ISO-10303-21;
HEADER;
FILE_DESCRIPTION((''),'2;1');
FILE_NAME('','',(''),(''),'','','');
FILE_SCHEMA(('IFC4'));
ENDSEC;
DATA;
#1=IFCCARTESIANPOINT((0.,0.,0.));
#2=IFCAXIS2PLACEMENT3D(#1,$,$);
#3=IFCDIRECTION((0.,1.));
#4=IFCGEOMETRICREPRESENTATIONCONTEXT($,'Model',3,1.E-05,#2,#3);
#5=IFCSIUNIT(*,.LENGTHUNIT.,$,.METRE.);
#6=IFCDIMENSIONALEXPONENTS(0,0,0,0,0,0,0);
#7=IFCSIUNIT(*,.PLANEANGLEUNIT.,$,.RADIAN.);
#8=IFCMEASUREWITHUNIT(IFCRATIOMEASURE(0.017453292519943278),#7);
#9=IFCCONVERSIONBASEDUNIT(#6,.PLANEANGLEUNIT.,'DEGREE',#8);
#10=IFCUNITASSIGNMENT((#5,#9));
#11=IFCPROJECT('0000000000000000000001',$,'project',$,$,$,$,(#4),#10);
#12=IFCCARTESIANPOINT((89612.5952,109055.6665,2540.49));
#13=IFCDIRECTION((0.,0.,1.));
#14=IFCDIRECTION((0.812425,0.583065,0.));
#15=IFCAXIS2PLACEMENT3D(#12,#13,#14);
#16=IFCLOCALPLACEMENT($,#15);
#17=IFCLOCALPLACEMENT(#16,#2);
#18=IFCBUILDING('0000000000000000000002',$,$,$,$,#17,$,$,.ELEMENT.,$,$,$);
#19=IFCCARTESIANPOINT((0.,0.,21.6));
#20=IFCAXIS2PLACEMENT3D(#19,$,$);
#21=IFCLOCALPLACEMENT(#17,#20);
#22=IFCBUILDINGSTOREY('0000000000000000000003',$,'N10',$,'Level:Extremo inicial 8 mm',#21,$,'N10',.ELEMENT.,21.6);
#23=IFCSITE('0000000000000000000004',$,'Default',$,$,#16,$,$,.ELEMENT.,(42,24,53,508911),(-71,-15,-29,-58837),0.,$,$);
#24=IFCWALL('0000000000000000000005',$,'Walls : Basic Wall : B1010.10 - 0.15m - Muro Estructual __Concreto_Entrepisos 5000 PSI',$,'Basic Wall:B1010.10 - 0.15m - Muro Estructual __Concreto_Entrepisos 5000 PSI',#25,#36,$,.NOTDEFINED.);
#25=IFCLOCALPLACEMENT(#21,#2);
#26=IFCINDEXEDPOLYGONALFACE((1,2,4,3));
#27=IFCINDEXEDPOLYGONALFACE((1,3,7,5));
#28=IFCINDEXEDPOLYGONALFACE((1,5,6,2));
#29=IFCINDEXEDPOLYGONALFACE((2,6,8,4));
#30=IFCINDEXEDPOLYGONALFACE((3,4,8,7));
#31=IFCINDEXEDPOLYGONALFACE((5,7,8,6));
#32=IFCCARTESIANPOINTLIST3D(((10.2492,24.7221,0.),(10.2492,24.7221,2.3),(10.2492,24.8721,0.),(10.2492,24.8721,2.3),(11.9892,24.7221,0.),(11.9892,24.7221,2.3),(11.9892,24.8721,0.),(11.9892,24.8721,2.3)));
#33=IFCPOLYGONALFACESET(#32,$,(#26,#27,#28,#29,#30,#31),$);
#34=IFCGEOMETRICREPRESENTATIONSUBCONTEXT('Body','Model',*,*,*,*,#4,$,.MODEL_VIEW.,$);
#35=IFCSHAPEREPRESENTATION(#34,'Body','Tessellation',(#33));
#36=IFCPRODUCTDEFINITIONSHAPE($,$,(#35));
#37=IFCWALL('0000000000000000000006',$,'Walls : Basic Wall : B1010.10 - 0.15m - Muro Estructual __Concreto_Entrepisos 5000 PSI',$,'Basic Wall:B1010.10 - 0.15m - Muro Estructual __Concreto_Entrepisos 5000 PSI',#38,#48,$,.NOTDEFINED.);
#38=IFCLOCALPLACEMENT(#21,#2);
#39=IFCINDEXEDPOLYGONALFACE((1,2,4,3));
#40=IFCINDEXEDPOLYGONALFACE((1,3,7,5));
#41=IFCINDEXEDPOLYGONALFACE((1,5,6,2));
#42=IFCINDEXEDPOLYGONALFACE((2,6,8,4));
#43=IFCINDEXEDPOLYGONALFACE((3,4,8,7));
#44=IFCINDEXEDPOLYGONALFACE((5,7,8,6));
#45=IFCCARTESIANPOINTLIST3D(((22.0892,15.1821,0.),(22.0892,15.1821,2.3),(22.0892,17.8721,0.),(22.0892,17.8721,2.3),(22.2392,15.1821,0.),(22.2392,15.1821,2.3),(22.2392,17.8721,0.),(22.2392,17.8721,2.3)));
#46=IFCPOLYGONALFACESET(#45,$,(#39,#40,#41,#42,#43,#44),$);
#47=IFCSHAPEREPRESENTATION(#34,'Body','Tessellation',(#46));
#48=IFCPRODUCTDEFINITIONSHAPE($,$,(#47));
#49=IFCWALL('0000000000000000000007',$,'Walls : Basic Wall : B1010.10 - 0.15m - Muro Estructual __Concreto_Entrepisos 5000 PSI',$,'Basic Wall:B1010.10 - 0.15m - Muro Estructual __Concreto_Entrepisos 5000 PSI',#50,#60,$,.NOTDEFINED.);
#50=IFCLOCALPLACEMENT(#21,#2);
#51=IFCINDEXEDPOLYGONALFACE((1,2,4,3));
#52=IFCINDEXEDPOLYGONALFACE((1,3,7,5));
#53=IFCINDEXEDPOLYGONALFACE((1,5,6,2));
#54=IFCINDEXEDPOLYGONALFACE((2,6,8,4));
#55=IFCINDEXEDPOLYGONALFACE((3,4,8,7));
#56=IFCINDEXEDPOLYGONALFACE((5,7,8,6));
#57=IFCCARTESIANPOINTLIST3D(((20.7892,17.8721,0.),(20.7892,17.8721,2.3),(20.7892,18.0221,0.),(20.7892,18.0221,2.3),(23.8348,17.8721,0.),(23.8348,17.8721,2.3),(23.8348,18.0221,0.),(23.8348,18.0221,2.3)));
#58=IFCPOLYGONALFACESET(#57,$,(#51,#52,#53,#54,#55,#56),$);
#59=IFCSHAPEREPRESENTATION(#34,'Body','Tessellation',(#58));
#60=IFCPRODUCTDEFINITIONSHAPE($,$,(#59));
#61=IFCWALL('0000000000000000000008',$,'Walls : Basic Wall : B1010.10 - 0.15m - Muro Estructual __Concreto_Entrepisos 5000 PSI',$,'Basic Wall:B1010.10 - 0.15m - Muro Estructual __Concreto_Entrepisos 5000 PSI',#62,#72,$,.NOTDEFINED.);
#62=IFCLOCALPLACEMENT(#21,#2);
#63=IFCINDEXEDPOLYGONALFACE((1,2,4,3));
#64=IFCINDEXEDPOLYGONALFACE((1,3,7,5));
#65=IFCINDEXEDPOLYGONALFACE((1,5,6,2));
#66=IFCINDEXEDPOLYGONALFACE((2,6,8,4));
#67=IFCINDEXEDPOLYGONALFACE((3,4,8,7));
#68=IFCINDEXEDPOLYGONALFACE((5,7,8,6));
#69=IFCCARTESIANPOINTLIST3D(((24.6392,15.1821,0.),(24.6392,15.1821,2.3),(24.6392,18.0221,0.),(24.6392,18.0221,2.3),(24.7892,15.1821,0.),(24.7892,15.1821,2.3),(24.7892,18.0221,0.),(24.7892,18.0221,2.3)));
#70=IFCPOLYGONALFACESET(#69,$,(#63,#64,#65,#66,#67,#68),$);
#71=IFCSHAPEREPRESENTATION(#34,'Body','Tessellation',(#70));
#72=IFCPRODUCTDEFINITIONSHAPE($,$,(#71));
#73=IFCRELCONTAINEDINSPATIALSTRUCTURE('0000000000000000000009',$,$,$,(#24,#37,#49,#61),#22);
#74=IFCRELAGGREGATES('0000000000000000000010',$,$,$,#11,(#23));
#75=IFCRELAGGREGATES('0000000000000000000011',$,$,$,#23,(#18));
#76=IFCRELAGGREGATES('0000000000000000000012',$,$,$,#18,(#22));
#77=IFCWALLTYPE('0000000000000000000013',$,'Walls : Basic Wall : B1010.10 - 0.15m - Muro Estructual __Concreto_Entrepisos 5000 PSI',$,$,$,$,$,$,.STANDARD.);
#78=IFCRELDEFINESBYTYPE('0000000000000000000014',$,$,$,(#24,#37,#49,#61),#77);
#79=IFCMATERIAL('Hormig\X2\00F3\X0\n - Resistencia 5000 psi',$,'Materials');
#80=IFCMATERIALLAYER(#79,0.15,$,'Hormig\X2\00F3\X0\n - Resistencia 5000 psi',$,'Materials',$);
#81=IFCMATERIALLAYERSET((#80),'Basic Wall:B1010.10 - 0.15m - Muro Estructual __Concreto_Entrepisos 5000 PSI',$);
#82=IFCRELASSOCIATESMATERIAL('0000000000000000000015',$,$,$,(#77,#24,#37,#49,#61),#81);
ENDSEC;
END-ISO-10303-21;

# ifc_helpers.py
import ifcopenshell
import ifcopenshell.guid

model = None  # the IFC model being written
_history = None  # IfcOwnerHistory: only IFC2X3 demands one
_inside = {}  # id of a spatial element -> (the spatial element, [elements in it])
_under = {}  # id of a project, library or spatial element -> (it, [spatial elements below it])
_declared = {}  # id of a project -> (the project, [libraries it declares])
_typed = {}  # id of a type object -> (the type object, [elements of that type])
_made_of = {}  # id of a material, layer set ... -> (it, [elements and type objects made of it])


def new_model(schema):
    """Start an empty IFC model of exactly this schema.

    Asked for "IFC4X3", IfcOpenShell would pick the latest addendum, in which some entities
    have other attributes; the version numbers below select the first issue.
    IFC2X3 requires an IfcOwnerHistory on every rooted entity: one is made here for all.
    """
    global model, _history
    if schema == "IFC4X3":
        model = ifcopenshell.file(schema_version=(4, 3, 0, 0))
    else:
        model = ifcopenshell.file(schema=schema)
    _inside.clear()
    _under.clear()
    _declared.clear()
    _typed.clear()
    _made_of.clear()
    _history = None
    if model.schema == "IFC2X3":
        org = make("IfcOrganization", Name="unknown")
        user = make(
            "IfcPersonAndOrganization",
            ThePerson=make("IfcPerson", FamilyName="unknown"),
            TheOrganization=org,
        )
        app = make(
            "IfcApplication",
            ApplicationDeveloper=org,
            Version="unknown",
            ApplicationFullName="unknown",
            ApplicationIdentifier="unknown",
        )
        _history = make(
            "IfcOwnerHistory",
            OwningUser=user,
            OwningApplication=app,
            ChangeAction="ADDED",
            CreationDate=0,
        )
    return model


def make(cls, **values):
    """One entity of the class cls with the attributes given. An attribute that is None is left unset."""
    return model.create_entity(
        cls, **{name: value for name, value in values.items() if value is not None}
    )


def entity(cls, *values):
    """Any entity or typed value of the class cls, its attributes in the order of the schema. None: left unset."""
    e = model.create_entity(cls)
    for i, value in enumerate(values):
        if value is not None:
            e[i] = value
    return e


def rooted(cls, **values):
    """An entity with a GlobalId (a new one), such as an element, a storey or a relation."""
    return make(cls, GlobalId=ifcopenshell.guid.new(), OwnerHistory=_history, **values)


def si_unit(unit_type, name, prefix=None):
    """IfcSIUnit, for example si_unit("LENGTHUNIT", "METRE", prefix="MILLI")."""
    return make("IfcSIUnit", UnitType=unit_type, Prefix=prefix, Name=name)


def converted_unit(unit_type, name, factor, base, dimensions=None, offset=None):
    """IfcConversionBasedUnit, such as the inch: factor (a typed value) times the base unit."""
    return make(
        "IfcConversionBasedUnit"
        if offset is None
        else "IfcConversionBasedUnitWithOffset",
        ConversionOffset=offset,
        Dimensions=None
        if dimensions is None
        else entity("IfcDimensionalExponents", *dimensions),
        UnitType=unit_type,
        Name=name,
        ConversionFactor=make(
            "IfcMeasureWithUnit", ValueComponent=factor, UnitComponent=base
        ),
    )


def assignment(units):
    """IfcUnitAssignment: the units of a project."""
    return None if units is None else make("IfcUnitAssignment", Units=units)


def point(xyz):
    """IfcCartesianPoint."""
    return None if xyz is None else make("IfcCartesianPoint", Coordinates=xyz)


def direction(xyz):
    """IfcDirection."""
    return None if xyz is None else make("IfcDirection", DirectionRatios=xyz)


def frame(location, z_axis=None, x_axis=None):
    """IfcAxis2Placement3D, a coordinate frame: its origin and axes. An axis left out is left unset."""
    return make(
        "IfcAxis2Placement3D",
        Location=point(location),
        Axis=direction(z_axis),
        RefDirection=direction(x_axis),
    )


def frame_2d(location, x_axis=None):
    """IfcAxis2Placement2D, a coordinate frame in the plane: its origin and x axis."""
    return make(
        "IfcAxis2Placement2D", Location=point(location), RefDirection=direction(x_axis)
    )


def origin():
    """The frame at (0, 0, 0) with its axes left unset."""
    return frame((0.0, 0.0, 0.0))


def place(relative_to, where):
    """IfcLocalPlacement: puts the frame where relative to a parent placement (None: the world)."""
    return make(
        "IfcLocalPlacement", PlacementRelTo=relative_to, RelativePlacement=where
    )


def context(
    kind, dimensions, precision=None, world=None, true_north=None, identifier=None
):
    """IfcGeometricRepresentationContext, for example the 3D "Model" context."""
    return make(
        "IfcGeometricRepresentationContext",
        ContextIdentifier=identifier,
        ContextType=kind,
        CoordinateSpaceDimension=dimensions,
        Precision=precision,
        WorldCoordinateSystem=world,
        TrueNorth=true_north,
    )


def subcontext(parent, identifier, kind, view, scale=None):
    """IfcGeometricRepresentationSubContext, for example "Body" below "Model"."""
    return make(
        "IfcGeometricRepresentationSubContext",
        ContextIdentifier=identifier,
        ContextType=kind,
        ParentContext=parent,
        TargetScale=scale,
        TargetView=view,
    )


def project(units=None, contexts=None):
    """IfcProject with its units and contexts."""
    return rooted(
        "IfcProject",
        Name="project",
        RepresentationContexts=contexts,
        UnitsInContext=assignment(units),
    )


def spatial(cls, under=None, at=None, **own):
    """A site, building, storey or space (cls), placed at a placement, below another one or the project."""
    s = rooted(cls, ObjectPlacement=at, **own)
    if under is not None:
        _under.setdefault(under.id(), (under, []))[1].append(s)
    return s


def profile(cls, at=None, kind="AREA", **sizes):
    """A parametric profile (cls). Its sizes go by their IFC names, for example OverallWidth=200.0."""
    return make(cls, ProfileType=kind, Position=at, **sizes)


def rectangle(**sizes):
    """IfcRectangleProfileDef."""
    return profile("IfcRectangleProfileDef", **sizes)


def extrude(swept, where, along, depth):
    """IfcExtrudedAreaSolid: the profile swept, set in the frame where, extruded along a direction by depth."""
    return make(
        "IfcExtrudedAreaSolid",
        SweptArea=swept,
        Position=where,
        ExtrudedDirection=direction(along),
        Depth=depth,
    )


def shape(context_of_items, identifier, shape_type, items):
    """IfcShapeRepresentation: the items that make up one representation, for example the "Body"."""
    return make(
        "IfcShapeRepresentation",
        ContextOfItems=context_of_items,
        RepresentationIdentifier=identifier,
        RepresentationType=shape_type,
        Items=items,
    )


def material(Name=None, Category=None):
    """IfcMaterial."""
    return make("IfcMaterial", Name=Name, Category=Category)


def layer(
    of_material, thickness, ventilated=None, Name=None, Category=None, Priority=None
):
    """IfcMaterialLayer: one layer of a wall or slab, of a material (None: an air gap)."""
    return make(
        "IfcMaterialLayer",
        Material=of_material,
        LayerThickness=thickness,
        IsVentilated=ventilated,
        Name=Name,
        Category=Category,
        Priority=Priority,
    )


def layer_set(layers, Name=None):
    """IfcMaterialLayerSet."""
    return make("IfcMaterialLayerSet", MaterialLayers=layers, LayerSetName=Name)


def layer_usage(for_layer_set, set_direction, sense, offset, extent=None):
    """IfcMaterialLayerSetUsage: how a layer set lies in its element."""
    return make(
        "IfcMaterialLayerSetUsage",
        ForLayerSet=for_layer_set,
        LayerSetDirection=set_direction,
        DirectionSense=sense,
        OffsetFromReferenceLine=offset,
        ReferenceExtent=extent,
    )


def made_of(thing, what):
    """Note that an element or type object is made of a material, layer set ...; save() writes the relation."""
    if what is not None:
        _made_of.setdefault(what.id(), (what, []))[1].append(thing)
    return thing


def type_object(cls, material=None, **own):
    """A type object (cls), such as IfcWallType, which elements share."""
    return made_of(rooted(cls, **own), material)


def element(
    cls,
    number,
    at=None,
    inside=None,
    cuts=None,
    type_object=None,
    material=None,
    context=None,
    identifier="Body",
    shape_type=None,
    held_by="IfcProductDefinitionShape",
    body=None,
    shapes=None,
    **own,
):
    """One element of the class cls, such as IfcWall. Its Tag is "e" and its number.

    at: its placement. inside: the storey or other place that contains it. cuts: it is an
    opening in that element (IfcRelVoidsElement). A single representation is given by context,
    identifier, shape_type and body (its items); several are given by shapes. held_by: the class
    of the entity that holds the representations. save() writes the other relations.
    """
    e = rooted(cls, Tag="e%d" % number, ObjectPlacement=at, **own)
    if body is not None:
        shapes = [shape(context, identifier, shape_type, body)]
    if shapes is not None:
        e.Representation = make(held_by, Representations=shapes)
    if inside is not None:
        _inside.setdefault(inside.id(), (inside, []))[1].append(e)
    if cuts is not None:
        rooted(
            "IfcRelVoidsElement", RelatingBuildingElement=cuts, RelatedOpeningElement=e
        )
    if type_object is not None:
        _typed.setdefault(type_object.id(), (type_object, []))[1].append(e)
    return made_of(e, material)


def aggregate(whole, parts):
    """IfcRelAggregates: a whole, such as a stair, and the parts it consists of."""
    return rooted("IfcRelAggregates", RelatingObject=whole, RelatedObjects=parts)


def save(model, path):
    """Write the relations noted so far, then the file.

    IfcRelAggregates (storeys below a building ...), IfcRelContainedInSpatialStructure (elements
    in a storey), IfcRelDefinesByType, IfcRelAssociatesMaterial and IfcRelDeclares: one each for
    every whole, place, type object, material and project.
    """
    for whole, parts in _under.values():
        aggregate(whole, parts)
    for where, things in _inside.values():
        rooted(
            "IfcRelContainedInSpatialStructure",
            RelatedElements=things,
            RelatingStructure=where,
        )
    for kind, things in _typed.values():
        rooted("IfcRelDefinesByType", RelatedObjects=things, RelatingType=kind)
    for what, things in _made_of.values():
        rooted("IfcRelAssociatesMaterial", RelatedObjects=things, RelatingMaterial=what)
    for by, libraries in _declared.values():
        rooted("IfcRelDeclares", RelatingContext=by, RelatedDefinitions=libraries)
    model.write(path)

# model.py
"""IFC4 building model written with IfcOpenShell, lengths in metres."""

from ifc_helpers import new_model, entity, si_unit, converted_unit, direction, frame, frame_2d, origin, place, context, subcontext, project, spatial, rectangle, extrude, material, layer, layer_set, layer_usage, type_object, element, save


model = new_model("IFC4")

# Units and contexts
model_context = context("Model", 3, precision=1e-05, world=origin(), true_north=direction((0.0, 1.0)))
body_context = subcontext(model_context, "Body", "Model", "MODEL_VIEW")
ifc_project = project(units=[si_unit("LENGTHUNIT", "METRE"), converted_unit("PLANEANGLEUNIT", "DEGREE", entity("IfcRatioMeasure", 0.017453292519943278), si_unit("PLANEANGLEUNIT", "RADIAN"), dimensions=[0, 0, 0, 0, 0, 0, 0])], contexts=[model_context])

# Site, building, storey
site_placement = place(None, frame((89612.5952, 109055.6665, 2540.49), z_axis=(0.0, 0.0, 1.0), x_axis=(0.812425, 0.583065, 0.0)))
site = spatial("IfcSite", under=ifc_project, at=site_placement, Name="Default", CompositionType="ELEMENT", RefLatitude=(42, 24, 53, 508911), RefLongitude=(-71, -15, -29, -58837), RefElevation=0.0)
building_placement = place(site_placement, origin())
building = spatial("IfcBuilding", under=site, at=building_placement, CompositionType="ELEMENT")
storey_placement = place(building_placement, frame((0.0, 0.0, 21.6)))
storey = spatial("IfcBuildingStorey", under=building, at=storey_placement, Name="N10", ObjectType="Level:Extremo inicial 8 mm", LongName="N10", CompositionType="ELEMENT", Elevation=21.6)

# Walls
ifc_material = material(Name="Hormigón - Resistencia 5000 psi", Category="Materials")
ifc_layer_1 = layer(ifc_material, 0.15, Name="Hormigón - Resistencia 5000 psi", Category="Materials")
ifc_layer_set_1 = layer_set([ifc_layer_1], Name="Basic Wall:B1010.10 - 0.15m - Muro Estructual __Concreto_Entrepisos 5000 PSI")
wall_type_1 = type_object("IfcWallType", Name="Walls : Basic Wall : B1010.10 - 0.15m - Muro Estructual __Concreto_Entrepisos 5000 PSI", PredefinedType="STANDARD", material=ifc_layer_set_1)
ifc_layer_usage_1 = layer_usage(ifc_layer_set_1, "AXIS2", "POSITIVE", -0.075)
wall_1_placement = place(storey_placement, frame((11.9892, 24.7971, 0.0), z_axis=(0.0, 0.0, 1.0), x_axis=(-1.0, 0.0, 0.0)))
element("IfcWall", 1, at=wall_1_placement, inside=storey, type_object=wall_type_1, material=ifc_layer_usage_1, Name="Walls : Basic Wall : B1010.10 - 0.15m - Muro Estructual __Concreto_Entrepisos 5000 PSI", ObjectType="Basic Wall:B1010.10 - 0.15m - Muro Estructual __Concreto_Entrepisos 5000 PSI", PredefinedType="NOTDEFINED", context=body_context, shape_type="SweptSolid", body=[
    extrude(rectangle(XDim=1.74, YDim=0.15, at=frame_2d((0.87, 0.0), x_axis=(-1.0, 0.0))), origin(), (0.0, 0.0, 1.0), 2.3),
])
ifc_layer_usage_2 = layer_usage(ifc_layer_set_1, "AXIS2", "POSITIVE", -0.075)
wall_2_placement = place(storey_placement, frame((22.1642, 15.1821, 0.0), z_axis=(0.0, 0.0, 1.0), x_axis=(0.0, 1.0, 0.0)))
element("IfcWall", 2, at=wall_2_placement, inside=storey, type_object=wall_type_1, material=ifc_layer_usage_2, Name="Walls : Basic Wall : B1010.10 - 0.15m - Muro Estructual __Concreto_Entrepisos 5000 PSI", ObjectType="Basic Wall:B1010.10 - 0.15m - Muro Estructual __Concreto_Entrepisos 5000 PSI", PredefinedType="NOTDEFINED", context=body_context, shape_type="SweptSolid", body=[
    extrude(rectangle(XDim=2.69, YDim=0.15, at=frame_2d((1.345, 0.0), x_axis=(-1.0, 0.0))), origin(), (0.0, 0.0, 1.0), 2.3),
])
ifc_layer_usage_3 = layer_usage(ifc_layer_set_1, "AXIS2", "POSITIVE", -0.075)
wall_3_placement = place(storey_placement, frame((20.7892, 17.9471, 0.0)))
element("IfcWall", 3, at=wall_3_placement, inside=storey, type_object=wall_type_1, material=ifc_layer_usage_3, Name="Walls : Basic Wall : B1010.10 - 0.15m - Muro Estructual __Concreto_Entrepisos 5000 PSI", ObjectType="Basic Wall:B1010.10 - 0.15m - Muro Estructual __Concreto_Entrepisos 5000 PSI", PredefinedType="NOTDEFINED", context=body_context, shape_type="SweptSolid", body=[
    extrude(rectangle(XDim=3.0455, YDim=0.15, at=frame_2d((1.5228, 0.0), x_axis=(-1.0, 0.0))), origin(), (0.0, 0.0, 1.0), 2.3),
])
ifc_layer_usage_4 = layer_usage(ifc_layer_set_1, "AXIS2", "POSITIVE", -0.075)
wall_4_placement = place(storey_placement, frame((24.7142, 15.1821, 0.0), z_axis=(0.0, 0.0, 1.0), x_axis=(0.0, 1.0, 0.0)))
element("IfcWall", 4, at=wall_4_placement, inside=storey, type_object=wall_type_1, material=ifc_layer_usage_4, Name="Walls : Basic Wall : B1010.10 - 0.15m - Muro Estructual __Concreto_Entrepisos 5000 PSI", ObjectType="Basic Wall:B1010.10 - 0.15m - Muro Estructual __Concreto_Entrepisos 5000 PSI", PredefinedType="NOTDEFINED", context=body_context, shape_type="SweptSolid", body=[
    extrude(rectangle(XDim=2.84, YDim=0.15, at=frame_2d((1.42, 0.0), x_axis=(-1.0, 0.0))), origin(), (0.0, 0.0, 1.0), 2.3),
])

save(model, "model.ifc")
